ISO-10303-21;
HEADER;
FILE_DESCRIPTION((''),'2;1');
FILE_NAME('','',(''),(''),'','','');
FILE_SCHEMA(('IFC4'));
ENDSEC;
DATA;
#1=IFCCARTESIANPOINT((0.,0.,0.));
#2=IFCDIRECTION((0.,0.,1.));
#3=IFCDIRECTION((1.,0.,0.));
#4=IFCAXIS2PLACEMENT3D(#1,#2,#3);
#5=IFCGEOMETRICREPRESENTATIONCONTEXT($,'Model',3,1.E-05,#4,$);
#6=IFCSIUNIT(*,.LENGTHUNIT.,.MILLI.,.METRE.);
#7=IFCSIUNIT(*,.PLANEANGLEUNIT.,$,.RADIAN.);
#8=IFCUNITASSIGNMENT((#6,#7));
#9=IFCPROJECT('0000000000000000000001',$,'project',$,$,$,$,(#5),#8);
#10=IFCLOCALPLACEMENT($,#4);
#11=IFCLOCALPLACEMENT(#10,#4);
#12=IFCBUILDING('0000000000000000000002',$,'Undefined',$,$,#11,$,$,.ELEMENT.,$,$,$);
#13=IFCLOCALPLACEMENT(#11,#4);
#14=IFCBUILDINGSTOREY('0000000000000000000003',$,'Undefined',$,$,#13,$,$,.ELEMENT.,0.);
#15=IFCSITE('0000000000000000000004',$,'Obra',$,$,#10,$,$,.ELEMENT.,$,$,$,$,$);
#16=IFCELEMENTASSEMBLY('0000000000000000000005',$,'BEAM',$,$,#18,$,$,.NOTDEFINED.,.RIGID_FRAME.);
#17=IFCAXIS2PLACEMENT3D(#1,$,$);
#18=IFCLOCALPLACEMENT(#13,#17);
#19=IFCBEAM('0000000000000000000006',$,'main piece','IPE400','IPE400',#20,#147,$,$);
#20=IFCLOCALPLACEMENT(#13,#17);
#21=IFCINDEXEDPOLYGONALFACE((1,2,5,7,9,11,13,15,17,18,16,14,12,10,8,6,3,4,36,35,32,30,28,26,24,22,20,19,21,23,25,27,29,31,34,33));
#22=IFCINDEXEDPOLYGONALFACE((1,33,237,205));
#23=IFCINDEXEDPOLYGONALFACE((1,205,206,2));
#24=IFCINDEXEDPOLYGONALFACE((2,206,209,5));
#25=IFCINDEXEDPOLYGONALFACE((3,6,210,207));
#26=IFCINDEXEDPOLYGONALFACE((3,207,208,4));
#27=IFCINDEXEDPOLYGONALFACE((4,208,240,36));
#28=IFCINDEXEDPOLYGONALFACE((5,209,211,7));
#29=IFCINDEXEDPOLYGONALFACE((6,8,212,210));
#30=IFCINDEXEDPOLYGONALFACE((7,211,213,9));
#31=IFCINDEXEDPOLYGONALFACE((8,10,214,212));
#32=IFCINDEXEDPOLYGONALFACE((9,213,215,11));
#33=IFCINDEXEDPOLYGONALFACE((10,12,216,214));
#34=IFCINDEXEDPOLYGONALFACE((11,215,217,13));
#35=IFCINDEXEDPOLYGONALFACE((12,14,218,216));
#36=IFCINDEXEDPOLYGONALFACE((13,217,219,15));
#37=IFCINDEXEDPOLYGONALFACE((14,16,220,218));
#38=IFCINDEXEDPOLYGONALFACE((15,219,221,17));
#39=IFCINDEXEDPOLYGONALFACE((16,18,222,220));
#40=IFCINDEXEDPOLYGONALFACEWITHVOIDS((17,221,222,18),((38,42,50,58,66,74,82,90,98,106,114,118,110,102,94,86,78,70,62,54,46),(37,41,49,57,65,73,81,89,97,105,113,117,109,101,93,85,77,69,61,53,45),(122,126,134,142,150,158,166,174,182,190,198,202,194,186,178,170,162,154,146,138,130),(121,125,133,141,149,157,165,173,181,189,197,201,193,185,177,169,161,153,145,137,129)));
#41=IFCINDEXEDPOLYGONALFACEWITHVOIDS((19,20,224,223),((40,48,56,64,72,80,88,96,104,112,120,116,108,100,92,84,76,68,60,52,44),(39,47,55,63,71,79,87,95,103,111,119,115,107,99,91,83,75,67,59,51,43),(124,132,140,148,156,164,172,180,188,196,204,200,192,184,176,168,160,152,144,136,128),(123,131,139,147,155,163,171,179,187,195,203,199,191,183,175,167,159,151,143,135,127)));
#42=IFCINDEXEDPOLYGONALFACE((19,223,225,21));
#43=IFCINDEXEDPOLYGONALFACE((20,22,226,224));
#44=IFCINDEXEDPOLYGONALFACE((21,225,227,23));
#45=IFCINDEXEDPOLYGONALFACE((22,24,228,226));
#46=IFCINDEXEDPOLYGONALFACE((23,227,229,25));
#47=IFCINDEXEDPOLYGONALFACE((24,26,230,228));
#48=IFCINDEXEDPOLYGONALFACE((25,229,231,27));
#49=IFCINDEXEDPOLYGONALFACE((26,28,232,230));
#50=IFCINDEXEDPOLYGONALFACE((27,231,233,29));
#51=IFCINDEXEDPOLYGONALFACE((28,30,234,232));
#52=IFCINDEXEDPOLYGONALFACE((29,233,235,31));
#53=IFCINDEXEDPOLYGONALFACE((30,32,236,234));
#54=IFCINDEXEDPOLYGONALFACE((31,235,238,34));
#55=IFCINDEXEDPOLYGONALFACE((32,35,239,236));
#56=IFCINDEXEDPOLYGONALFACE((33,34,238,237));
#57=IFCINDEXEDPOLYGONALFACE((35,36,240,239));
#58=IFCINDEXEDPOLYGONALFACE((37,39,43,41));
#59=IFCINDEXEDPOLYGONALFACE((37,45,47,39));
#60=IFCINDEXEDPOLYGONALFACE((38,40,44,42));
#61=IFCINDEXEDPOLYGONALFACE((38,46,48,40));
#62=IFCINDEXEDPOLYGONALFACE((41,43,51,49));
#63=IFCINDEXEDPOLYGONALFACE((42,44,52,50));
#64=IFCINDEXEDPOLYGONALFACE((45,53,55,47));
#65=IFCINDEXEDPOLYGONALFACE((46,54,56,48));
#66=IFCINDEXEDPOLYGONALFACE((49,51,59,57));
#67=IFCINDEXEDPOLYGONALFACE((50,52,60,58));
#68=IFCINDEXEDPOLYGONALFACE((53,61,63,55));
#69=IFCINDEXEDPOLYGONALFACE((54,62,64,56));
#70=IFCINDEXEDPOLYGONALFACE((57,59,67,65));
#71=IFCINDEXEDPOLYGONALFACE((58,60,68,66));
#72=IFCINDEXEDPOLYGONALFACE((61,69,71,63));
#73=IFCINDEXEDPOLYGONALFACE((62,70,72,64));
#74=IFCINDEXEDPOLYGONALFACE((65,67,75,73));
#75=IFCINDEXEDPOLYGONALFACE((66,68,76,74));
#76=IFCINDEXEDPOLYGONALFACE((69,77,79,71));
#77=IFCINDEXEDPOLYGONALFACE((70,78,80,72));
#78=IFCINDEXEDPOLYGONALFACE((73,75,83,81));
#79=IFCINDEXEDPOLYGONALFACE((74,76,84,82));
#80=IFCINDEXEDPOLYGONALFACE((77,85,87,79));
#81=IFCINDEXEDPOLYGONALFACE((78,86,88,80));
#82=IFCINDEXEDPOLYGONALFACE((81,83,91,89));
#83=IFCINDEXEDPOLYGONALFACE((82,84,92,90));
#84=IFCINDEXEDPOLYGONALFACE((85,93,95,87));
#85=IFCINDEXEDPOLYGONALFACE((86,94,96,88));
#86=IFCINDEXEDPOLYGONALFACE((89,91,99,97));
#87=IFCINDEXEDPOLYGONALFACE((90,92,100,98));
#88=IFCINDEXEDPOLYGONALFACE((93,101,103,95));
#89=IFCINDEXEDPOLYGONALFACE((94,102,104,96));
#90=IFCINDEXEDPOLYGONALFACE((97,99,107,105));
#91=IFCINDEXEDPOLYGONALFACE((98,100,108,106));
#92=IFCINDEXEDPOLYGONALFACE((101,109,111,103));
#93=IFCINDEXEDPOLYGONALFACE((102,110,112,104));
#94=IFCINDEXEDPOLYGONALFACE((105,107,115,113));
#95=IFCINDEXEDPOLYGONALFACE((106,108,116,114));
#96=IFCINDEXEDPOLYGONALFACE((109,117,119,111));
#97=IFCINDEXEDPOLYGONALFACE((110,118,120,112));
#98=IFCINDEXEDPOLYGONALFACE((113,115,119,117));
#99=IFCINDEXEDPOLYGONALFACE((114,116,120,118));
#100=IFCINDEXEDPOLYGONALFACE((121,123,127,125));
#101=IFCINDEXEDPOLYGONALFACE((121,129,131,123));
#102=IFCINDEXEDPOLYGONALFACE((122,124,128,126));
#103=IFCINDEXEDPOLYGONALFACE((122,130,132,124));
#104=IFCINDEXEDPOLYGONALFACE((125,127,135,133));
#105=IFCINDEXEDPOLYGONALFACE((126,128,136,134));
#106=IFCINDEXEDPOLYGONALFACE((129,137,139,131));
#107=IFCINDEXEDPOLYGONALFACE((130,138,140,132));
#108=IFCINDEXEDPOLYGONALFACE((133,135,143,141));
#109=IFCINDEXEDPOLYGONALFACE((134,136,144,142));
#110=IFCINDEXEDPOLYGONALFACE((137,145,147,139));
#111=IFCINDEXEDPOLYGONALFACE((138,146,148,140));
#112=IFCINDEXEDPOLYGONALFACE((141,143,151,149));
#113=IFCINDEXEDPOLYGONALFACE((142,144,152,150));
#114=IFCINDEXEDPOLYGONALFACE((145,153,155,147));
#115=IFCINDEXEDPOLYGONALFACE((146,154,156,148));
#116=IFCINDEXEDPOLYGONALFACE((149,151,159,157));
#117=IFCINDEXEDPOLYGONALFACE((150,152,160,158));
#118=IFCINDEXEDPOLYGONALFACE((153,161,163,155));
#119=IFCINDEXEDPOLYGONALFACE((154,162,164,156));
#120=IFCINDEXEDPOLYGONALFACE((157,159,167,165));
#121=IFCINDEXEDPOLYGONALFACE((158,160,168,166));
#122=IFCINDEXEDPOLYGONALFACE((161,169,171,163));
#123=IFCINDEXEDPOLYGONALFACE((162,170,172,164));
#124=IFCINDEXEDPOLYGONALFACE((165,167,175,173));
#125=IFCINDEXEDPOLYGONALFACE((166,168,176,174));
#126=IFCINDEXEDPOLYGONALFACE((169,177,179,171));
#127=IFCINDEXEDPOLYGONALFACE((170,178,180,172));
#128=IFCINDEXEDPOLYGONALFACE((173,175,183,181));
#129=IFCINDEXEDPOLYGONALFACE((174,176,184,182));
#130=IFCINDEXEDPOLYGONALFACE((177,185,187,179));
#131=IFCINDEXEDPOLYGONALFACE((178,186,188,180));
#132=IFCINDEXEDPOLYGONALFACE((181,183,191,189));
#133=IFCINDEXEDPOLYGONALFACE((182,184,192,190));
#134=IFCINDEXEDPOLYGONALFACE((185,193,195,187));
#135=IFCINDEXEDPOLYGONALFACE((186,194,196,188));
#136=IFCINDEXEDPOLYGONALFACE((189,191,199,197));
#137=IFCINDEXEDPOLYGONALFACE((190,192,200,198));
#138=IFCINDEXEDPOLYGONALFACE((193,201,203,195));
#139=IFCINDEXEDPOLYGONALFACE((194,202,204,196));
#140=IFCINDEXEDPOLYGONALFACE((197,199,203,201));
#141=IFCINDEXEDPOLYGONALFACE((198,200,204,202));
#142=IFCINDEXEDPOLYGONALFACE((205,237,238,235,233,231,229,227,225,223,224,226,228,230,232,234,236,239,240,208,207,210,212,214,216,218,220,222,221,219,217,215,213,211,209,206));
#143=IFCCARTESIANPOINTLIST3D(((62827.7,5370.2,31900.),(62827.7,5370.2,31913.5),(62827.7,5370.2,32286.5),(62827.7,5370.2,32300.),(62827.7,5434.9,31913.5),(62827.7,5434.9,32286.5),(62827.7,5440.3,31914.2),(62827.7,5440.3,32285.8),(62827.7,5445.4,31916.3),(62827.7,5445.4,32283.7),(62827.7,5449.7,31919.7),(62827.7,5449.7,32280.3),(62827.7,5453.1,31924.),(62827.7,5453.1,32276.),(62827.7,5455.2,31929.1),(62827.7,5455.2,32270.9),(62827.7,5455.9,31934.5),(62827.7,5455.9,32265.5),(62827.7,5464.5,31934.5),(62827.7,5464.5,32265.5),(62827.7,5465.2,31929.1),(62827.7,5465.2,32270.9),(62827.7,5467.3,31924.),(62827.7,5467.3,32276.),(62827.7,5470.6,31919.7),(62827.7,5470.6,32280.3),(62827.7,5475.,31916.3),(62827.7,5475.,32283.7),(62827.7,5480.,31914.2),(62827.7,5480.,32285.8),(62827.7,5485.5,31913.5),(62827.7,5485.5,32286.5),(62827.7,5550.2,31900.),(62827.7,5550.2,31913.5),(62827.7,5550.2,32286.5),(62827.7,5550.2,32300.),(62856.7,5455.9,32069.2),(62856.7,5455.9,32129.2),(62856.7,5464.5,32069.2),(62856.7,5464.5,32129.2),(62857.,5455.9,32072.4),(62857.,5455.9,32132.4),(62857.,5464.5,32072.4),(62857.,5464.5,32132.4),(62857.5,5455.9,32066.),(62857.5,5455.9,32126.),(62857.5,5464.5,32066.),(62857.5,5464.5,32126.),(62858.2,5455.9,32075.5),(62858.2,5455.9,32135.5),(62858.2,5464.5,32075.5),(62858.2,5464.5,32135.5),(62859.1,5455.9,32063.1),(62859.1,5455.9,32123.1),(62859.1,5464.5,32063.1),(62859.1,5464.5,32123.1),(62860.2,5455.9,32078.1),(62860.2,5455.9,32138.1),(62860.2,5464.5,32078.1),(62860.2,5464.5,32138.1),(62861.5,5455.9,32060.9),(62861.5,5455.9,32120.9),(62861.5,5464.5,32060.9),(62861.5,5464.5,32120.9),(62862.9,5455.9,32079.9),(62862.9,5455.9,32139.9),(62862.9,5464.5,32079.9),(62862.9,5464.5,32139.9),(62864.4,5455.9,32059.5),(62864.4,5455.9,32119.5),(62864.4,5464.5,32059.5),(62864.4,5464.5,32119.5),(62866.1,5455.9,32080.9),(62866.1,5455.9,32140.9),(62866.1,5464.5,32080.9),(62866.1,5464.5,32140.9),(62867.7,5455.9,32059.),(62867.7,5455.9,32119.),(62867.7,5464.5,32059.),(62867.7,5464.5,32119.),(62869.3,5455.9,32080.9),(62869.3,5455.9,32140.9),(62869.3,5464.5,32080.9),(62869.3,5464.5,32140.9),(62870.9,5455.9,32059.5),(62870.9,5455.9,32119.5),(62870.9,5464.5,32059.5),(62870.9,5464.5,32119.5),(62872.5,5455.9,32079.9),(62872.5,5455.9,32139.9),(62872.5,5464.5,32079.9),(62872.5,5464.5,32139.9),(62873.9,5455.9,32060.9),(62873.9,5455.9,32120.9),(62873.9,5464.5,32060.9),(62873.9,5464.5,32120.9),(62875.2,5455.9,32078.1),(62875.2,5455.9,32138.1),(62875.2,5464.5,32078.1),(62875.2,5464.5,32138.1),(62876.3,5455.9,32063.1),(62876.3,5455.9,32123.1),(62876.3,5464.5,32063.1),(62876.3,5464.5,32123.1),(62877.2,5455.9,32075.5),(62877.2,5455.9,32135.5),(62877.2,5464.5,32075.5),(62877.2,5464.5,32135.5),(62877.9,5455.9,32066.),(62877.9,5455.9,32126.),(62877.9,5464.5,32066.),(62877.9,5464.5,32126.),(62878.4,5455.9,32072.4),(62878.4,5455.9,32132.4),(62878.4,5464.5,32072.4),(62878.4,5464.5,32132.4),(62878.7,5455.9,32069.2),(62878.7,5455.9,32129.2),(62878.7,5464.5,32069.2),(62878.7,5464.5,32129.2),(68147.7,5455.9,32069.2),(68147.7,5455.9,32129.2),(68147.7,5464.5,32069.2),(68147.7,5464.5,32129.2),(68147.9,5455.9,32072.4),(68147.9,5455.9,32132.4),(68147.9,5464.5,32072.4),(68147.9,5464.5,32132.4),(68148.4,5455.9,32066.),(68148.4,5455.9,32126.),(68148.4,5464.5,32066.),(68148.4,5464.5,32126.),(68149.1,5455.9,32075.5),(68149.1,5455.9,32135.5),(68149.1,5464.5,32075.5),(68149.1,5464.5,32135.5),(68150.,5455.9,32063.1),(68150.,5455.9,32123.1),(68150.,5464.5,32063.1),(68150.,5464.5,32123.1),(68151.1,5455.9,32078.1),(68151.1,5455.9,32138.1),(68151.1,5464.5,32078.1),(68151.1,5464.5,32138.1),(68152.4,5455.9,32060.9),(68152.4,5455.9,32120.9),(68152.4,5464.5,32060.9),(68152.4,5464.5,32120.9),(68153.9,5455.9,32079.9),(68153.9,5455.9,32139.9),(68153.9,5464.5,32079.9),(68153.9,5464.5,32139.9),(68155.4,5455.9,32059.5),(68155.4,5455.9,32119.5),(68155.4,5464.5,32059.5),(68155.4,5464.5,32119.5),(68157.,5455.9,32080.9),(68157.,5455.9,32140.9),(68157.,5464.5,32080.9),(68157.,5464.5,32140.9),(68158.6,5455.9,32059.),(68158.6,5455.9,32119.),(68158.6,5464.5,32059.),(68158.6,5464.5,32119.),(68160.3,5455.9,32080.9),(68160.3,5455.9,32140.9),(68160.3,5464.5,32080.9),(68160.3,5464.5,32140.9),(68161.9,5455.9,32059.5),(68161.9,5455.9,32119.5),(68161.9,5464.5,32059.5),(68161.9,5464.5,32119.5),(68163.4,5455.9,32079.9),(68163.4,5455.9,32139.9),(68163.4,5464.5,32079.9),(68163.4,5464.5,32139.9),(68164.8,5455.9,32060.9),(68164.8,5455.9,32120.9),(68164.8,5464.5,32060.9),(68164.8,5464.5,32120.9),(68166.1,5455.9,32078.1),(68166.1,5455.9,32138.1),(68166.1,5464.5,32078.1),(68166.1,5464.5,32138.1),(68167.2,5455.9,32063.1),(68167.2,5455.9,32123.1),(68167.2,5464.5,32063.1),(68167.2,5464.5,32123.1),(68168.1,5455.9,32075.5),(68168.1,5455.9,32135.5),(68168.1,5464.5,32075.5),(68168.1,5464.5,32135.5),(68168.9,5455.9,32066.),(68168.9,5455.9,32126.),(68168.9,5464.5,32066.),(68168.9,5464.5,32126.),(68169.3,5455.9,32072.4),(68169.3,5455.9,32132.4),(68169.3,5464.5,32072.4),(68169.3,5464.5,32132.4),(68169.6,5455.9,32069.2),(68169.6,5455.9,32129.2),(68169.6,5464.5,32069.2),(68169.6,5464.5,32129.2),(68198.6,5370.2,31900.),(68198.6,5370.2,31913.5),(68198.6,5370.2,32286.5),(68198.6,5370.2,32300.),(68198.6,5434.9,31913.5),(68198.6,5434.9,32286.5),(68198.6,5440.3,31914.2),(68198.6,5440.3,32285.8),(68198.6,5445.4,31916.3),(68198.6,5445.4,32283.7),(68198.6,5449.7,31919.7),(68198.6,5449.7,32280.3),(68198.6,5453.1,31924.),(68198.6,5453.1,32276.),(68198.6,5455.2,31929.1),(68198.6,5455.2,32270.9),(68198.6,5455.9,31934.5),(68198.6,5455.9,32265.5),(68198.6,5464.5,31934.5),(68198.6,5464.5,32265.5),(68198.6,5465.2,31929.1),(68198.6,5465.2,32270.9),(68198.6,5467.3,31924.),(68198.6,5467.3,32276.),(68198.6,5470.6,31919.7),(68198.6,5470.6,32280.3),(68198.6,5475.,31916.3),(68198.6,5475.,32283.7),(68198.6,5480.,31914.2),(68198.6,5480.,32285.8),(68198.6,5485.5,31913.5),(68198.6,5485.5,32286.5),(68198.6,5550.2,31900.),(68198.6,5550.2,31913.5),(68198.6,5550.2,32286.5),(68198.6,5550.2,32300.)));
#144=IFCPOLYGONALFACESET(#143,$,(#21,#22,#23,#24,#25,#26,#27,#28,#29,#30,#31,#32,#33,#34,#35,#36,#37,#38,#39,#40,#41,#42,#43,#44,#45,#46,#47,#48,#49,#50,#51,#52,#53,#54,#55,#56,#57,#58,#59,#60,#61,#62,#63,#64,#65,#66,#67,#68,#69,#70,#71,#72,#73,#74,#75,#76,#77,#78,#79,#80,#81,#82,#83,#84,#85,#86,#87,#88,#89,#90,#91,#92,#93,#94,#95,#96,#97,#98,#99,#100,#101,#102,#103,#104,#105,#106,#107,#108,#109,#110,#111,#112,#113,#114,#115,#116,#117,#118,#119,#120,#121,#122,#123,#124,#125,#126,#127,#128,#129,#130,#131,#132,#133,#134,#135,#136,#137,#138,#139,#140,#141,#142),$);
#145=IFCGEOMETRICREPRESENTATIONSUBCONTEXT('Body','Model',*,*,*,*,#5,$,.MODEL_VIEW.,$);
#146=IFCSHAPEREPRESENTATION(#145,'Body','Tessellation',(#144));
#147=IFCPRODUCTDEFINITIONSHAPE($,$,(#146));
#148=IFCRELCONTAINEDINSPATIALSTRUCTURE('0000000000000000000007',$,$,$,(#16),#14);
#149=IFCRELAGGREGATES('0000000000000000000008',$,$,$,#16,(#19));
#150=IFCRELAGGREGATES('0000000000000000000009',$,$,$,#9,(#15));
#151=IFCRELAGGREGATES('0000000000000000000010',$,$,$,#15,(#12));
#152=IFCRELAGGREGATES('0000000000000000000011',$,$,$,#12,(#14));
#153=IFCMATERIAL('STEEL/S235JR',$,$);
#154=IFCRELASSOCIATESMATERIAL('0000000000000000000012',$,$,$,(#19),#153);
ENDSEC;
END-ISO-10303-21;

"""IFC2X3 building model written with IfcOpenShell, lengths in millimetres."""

from ifc_helpers import new_model, si_unit, frame, origin_with_axes, origin_2d_with_axis, place, context, subcontext, project, spatial, rectangle, circle, i_section, extrude, clip, halfspace, source, transform, mapped, material, element, aggregate, save


model = new_model("IFC2X3")

# Units and contexts
model_context = context("Model", 3, precision=1e-05, world=origin_with_axes())
body_context = subcontext(model_context, "Body", "Model", "MODEL_VIEW")
ifc_project = project(units=[si_unit("LENGTHUNIT", "METRE", prefix="MILLI"), si_unit("PLANEANGLEUNIT", "RADIAN")], contexts=[model_context])

# Site, building, storey
site_placement = place(None, origin_with_axes())
site = spatial("IfcSite", under=ifc_project, at=site_placement, Name="Obra", CompositionType="ELEMENT")
building_placement = place(site_placement, origin_with_axes())
building = spatial("IfcBuilding", under=site, at=building_placement, Name="Undefined", CompositionType="ELEMENT")
storey_placement = place(building_placement, origin_with_axes())
storey = spatial("IfcBuildingStorey", under=building, at=storey_placement, Name="Undefined", CompositionType="ELEMENT", Elevation=0.0)

# Shared definitions
ifc_material_1 = material(Name="STEEL/S235JR")

# Element assembly, beam, openings
assembly_1_placement = place(storey_placement, origin_with_axes())
assembly_1 = element("IfcElementAssembly", 1, at=assembly_1_placement, inside=storey, Name="BEAM", AssemblyPlace="NOTDEFINED", PredefinedType="RIGID_FRAME")
beam_1_placement = place(assembly_1_placement, frame((62837.7, 5460.2, 32100.0), z_axis=(0.0, 0.0, 1.0), x_axis=(1.0, 0.0, 0.0)))
beam_1 = element("IfcBeam", 2, at=beam_1_placement, material=ifc_material_1, Name="main piece", Description="IPE400", ObjectType="IPE400", context=body_context, shape_type="Clipping", body=[
    clip(clip(extrude(i_section(OverallWidth=180.0, OverallDepth=400.0, WebThickness=8.6, FlangeThickness=13.5, FilletRadius=21.0, at=origin_2d_with_axis()), frame((5360.9, 0.0, 0.0), z_axis=(-1.0, 0.0, 0.0), x_axis=(0.0, -1.0, 0.0)), (0.0, 0.0, 1.0), 5370.9), halfspace(frame((5360.9, 0.0, -300.0), z_axis=(-1.0, 0.0, 0.0), x_axis=(0.0, 1.0, 0.0)), True)), halfspace(frame((-10.0, 0.0, -300.0), z_axis=(1.0, 0.0, 0.0), x_axis=(0.0, -1.0, 0.0)), True)),
])
opening_1_placement = place(assembly_1_placement, frame((62837.7, 5460.2, 32100.0), z_axis=(0.0, 0.0, 1.0), x_axis=(1.0, 0.0, 0.0)))
element("IfcOpeningElement", 3, at=opening_1_placement, cuts=beam_1, ObjectType="Recess", context=body_context, shape_type="SweptSolid", body=[
    extrude(rectangle(XDim=35.5, YDim=97.7, at=origin_2d_with_axis()), frame((5409.8, 91.0, -183.2), z_axis=(0.0, -1.0, 0.0), x_axis=(0.0, 0.0, -1.0)), (0.0, 0.0, 1.0), 182.0),
])
opening_2_placement = place(assembly_1_placement, frame((62837.7, 5460.2, 32100.0), z_axis=(0.0, 0.0, 1.0), x_axis=(1.0, 0.0, 0.0)))
element("IfcOpeningElement", 4, at=opening_2_placement, cuts=beam_1, ObjectType="Recess", context=body_context, shape_type="SweptSolid", body=[
    extrude(rectangle(XDim=35.5, YDim=97.7, at=origin_2d_with_axis()), frame((5409.8, 91.0, 183.2), z_axis=(0.0, -1.0, 0.0), x_axis=(0.0, 0.0, -1.0)), (0.0, 0.0, 1.0), 182.0),
])
opening_3_placement = place(assembly_1_placement, frame((62837.7, 5460.2, 32100.0), z_axis=(0.0, 0.0, 1.0), x_axis=(1.0, 0.0, 0.0)))
element("IfcOpeningElement", 5, at=opening_3_placement, cuts=beam_1, ObjectType="Recess", context=body_context, shape_type="SweptSolid", body=[
    extrude(rectangle(XDim=35.5, YDim=97.7, at=origin_2d_with_axis()), frame((-58.8, -91.0, -183.2), z_axis=(0.0, 1.0, 0.0), x_axis=(0.0, 0.0, -1.0)), (0.0, 0.0, 1.0), 182.0),
])
opening_4_placement = place(assembly_1_placement, frame((62837.7, 5460.2, 32100.0), z_axis=(0.0, 0.0, 1.0), x_axis=(1.0, 0.0, 0.0)))
element("IfcOpeningElement", 6, at=opening_4_placement, cuts=beam_1, ObjectType="Recess", context=body_context, shape_type="SweptSolid", body=[
    extrude(rectangle(XDim=35.5, YDim=97.7, at=origin_2d_with_axis()), frame((-58.8, -91.0, 183.2), z_axis=(0.0, 1.0, 0.0), x_axis=(0.0, 0.0, -1.0)), (0.0, 0.0, 1.0), 182.0),
])
shared_shape_1 = source(origin_with_axes(), body_context, "Body", "SweptSolid", [
    extrude(circle(Radius=11.0, at=origin_2d_with_axis()), frame((0.0, -4.4, 0.0), z_axis=(0.0, 1.0, 0.0), x_axis=(1.0, 0.0, 0.0)), (0.0, 0.0, 1.0), 8.8),
])
opening_5_placement = place(assembly_1_placement, frame((68198.6, 5460.2, 32170.0), z_axis=(-1.0, 0.0, 0.0), x_axis=(0.0, 0.0, -1.0)))
element("IfcOpeningElement", 7, at=opening_5_placement, cuts=beam_1, ObjectType="Opening", context=body_context, shape_type="MappedRepresentation", body=[
    mapped(shared_shape_1, transform((40.0, 0.0, 40.0))),
    mapped(shared_shape_1, transform((100.0, 0.0, 40.0))),
])
shared_shape_2 = source(origin_with_axes(), body_context, "Body", "SweptSolid", [
    extrude(circle(Radius=11.0, at=origin_2d_with_axis()), frame((0.0, -4.4, 0.0), z_axis=(0.0, 1.0, 0.0), x_axis=(1.0, 0.0, 0.0)), (0.0, 0.0, 1.0), 8.8),
])
opening_6_placement = place(assembly_1_placement, frame((62827.7, 5460.2, 32170.0), z_axis=(1.0, 0.0, 0.0), x_axis=(0.0, 0.0, -1.0)))
element("IfcOpeningElement", 8, at=opening_6_placement, cuts=beam_1, ObjectType="Opening", context=body_context, shape_type="MappedRepresentation", body=[
    mapped(shared_shape_2, transform((40.0, 0.0, 40.0))),
    mapped(shared_shape_2, transform((100.0, 0.0, 40.0))),
])

aggregate(assembly_1, [beam_1])

save(model, "model.ifc")
